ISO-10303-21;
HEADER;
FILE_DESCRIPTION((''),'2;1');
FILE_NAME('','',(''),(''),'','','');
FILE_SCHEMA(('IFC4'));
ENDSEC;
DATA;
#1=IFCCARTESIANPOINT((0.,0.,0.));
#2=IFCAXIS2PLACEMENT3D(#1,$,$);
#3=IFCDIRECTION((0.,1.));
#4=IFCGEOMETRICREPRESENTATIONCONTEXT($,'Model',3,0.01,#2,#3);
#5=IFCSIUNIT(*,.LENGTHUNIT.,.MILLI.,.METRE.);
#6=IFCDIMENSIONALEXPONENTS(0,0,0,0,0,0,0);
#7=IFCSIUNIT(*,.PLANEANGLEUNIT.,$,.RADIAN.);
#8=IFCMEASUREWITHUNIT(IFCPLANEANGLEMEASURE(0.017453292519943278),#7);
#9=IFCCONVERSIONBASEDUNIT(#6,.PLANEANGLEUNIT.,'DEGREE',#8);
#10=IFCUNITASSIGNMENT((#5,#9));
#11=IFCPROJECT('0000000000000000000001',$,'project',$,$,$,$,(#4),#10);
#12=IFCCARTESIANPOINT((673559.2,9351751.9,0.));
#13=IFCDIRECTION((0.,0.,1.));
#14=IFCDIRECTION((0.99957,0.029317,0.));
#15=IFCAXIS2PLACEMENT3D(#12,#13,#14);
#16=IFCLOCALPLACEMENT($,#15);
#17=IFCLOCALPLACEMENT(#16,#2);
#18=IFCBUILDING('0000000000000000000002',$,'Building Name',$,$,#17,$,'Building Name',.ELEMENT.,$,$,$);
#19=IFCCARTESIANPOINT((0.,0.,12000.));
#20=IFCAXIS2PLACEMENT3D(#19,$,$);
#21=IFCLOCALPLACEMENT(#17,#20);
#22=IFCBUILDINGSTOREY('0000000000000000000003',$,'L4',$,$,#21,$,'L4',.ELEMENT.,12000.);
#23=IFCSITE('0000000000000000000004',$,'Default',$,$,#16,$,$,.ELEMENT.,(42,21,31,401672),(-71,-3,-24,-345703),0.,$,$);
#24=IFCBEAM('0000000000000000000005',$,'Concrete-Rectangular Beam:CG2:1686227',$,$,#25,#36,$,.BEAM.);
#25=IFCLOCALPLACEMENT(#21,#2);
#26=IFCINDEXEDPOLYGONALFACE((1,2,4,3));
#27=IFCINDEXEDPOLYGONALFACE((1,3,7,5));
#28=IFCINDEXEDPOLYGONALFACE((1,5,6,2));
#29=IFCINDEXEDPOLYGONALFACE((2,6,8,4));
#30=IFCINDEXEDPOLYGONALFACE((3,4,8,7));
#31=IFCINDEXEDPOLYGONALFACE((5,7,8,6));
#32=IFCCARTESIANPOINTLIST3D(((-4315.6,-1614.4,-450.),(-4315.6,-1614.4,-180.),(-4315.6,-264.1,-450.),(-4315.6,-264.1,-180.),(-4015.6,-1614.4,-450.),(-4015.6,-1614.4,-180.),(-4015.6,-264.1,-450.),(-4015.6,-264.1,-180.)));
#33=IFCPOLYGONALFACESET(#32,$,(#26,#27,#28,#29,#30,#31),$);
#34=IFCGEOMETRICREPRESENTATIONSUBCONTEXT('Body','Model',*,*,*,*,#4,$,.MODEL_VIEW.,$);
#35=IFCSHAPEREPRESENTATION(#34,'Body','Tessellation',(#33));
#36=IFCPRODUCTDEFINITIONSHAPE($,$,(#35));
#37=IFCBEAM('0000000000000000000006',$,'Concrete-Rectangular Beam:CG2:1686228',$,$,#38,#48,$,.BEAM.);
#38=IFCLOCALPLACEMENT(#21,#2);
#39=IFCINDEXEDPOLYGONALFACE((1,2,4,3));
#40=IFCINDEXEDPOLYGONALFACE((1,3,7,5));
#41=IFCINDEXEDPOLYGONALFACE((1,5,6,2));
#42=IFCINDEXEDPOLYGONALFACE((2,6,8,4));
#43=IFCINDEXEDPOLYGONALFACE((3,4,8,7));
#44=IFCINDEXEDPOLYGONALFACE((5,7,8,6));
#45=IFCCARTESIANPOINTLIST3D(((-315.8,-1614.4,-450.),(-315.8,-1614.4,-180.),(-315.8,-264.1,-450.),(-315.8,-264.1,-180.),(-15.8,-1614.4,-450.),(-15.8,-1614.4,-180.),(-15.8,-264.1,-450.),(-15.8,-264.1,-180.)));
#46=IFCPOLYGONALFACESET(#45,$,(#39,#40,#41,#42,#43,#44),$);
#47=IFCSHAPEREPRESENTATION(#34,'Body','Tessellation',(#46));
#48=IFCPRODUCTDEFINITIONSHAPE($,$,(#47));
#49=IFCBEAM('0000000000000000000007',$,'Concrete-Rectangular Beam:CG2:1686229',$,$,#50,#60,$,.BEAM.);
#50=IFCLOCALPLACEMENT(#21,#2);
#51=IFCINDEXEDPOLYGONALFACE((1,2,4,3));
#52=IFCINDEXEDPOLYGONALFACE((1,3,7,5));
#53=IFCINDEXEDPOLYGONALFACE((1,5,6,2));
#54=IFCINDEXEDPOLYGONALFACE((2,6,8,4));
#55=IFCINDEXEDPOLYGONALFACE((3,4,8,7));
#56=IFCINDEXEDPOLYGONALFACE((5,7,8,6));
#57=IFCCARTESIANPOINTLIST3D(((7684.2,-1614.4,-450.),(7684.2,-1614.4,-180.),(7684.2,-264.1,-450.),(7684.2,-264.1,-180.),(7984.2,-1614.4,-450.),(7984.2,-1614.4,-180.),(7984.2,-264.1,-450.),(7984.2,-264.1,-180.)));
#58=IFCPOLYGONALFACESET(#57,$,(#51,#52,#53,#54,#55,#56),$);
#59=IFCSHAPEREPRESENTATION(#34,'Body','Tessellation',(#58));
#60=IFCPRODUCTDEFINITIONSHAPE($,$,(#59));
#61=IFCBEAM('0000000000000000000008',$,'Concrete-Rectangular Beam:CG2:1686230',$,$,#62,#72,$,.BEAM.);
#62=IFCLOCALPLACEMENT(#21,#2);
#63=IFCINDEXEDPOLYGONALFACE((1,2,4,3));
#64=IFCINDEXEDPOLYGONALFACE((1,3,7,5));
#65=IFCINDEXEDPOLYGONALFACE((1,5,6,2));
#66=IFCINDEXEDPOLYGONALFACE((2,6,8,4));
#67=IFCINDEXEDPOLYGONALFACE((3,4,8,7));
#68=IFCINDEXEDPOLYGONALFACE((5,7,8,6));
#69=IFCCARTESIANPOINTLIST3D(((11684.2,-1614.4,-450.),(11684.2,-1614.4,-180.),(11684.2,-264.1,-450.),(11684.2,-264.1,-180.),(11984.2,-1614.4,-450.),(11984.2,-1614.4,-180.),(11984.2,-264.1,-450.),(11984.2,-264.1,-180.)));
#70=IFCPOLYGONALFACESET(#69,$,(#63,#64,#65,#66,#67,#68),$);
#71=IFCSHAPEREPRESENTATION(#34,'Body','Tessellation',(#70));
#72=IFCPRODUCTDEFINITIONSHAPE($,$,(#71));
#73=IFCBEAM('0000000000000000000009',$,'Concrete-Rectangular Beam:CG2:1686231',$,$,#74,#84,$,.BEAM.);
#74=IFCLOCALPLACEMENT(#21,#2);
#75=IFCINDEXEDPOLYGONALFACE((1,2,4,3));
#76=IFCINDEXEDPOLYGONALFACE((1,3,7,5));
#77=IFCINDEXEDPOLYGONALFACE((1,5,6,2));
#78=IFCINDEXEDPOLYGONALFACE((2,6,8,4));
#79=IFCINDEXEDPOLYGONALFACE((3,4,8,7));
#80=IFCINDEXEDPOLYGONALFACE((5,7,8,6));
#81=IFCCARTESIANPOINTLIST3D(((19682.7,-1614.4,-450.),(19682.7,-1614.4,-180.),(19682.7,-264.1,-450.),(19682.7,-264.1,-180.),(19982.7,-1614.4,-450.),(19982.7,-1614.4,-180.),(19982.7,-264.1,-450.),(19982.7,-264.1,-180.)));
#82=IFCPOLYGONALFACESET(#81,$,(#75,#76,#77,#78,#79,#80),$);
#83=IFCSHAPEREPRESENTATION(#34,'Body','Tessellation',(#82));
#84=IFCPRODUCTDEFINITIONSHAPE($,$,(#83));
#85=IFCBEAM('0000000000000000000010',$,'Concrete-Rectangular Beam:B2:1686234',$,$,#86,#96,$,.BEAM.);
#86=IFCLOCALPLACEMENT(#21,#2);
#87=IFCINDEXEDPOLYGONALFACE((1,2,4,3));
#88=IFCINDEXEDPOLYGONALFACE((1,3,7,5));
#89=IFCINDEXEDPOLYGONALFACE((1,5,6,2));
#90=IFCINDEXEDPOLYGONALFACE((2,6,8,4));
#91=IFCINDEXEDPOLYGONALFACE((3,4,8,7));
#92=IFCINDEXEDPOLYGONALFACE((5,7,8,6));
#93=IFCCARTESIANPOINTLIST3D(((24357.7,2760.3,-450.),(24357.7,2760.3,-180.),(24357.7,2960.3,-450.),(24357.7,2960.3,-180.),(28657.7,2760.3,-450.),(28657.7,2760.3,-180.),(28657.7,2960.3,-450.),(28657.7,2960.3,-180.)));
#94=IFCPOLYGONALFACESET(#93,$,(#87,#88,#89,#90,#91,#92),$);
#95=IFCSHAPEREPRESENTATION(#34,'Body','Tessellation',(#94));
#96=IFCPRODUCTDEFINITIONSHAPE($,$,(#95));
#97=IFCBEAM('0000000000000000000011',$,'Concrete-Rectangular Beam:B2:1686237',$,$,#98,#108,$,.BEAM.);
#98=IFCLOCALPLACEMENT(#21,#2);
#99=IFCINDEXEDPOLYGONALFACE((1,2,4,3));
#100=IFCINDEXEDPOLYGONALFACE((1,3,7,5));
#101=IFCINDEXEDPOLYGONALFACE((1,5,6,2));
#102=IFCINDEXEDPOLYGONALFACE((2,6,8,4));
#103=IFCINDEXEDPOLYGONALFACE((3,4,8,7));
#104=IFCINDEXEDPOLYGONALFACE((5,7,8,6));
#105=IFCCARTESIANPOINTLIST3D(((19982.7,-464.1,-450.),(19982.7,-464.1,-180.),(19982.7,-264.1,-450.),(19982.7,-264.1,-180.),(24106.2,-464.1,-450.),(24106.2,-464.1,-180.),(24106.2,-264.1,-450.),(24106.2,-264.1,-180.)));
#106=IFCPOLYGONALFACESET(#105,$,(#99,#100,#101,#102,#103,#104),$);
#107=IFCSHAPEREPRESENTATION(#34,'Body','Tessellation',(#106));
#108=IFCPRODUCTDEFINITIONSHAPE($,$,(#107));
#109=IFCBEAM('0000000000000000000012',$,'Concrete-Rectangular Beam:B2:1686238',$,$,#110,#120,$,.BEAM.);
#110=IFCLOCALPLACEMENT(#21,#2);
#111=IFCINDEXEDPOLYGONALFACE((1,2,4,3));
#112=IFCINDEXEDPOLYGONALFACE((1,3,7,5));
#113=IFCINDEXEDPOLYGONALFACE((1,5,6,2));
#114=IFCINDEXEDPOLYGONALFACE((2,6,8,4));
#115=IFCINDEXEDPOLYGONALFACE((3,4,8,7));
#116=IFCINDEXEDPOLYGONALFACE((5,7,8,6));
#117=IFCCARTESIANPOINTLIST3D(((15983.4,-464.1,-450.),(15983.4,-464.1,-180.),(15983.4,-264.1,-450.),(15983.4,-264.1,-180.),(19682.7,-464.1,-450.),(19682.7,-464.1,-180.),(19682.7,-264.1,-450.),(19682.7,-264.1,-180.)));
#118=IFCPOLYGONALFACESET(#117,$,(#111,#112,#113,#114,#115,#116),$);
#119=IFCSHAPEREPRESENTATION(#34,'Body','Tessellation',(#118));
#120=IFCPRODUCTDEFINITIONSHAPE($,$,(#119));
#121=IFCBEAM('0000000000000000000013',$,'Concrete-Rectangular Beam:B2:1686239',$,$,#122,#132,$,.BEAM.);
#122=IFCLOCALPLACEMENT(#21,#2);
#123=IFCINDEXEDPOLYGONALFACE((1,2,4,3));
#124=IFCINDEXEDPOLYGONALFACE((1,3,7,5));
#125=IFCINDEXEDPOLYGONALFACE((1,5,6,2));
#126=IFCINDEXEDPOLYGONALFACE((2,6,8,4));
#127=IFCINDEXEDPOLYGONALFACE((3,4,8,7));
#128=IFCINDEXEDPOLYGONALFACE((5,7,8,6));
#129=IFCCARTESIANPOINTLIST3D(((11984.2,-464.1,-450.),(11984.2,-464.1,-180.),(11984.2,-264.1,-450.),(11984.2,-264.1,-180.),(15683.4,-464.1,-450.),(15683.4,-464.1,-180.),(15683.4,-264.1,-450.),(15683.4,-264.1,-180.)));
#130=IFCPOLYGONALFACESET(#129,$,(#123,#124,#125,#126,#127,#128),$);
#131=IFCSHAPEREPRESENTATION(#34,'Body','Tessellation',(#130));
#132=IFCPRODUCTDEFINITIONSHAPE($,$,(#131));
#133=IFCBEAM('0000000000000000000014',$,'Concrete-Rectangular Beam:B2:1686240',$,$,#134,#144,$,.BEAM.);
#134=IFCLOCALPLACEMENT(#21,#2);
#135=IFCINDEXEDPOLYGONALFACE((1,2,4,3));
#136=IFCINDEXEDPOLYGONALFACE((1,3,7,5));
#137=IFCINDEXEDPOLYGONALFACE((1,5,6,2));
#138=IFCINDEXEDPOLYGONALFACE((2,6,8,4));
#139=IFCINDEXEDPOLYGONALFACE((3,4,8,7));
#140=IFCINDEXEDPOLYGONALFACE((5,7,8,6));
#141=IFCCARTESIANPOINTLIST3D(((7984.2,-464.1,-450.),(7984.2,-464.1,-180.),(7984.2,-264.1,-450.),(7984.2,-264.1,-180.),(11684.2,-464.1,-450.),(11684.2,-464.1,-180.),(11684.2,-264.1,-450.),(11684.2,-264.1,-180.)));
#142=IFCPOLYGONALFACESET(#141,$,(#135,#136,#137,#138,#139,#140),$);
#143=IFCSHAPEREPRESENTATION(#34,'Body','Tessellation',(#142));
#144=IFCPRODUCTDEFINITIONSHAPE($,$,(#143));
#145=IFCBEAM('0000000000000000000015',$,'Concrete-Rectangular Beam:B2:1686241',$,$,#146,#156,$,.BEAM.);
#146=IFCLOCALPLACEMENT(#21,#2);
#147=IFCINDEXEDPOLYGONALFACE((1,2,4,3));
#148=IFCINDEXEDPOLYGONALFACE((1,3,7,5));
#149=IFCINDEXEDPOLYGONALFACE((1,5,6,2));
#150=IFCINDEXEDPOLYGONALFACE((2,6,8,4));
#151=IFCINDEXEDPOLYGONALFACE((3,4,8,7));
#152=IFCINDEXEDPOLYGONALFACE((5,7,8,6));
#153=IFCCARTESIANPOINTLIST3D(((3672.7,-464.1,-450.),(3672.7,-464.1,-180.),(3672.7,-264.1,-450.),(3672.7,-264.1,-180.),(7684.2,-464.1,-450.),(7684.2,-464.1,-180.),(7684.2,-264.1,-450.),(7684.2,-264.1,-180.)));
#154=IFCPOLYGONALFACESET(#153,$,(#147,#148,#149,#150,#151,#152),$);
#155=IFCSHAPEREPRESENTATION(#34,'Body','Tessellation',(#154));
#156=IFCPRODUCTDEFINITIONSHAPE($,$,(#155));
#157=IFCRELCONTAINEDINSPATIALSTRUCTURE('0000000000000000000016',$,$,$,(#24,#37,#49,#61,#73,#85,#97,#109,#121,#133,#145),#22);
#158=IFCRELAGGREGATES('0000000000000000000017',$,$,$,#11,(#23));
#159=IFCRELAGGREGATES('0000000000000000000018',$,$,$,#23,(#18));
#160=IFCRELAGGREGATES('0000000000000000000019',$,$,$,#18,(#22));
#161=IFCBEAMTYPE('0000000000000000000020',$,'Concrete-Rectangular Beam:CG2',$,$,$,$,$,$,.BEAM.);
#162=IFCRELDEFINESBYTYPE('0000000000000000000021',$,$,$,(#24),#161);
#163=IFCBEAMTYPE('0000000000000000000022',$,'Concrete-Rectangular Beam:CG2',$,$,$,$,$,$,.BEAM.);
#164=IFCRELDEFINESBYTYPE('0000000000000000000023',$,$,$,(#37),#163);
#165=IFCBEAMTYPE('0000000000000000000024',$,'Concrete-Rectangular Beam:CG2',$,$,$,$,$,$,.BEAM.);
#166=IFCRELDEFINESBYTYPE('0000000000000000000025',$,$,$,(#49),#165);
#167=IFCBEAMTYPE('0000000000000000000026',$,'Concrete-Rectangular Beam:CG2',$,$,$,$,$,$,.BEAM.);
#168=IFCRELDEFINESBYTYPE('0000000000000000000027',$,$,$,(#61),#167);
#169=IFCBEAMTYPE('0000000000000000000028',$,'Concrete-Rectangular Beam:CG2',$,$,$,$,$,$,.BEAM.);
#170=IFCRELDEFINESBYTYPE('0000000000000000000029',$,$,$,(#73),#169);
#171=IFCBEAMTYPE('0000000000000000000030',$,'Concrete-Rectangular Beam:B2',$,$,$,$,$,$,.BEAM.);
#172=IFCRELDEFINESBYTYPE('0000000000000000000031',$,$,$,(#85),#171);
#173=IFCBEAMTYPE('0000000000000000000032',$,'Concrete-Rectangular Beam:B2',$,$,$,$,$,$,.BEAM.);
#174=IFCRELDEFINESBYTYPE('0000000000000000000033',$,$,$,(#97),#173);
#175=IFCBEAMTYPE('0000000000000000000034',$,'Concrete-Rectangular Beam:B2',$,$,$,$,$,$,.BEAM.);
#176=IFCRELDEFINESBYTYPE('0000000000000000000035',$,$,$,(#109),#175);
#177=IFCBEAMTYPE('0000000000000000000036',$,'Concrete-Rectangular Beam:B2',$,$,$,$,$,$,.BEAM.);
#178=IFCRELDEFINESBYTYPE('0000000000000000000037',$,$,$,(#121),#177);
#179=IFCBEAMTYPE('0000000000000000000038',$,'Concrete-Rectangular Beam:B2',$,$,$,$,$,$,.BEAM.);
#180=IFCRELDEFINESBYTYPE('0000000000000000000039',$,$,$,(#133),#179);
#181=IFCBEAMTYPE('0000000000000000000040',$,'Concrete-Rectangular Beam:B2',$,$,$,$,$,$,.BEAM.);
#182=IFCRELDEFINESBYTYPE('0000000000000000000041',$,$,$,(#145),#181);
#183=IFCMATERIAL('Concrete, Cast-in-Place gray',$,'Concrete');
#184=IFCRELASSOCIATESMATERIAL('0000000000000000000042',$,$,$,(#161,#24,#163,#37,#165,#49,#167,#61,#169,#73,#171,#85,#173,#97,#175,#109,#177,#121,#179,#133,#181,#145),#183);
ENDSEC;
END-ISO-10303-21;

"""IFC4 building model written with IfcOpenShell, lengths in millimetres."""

from ifc_helpers import new_model, entity, si_unit, converted_unit, direction, frame, origin, place, context, subcontext, project, spatial, indexed_curve, outline, extrude, source, transform, mapped, material, type_object, type_shapes, element, save


model = new_model("IFC4")

# Units and contexts
model_context = context("Model", 3, precision=0.01, world=origin(), true_north=direction((0.0, 1.0)))
body_context = subcontext(model_context, "Body", "Model", "MODEL_VIEW")
ifc_project = project(units=[si_unit("LENGTHUNIT", "METRE", prefix="MILLI"), converted_unit("PLANEANGLEUNIT", "DEGREE", entity("IfcPlaneAngleMeasure", 0.017453292519943278), si_unit("PLANEANGLEUNIT", "RADIAN"), dimensions=[0, 0, 0, 0, 0, 0, 0])], contexts=[model_context])

# Site, building, storey
site_placement = place(None, frame((673559.2, 9351751.9, 0.0), z_axis=(0.0, 0.0, 1.0), x_axis=(0.99957, 0.029317, 0.0)))
site = spatial("IfcSite", under=ifc_project, at=site_placement, Name="Default", CompositionType="ELEMENT", RefLatitude=(42, 21, 31, 401672), RefLongitude=(-71, -3, -24, -345703), RefElevation=0.0)
building_placement = place(site_placement, origin())
building = spatial("IfcBuilding", under=site, at=building_placement, Name="Building Name", LongName="Building Name", CompositionType="ELEMENT")
storey_placement = place(building_placement, frame((0.0, 0.0, 12000.0)))
storey = spatial("IfcBuildingStorey", under=building, at=storey_placement, Name="L4", LongName="L4", CompositionType="ELEMENT", Elevation=12000.0)

# Beams
ifc_material = material(Name="Concrete, Cast-in-Place gray", Category="Concrete")
beam_type_1 = type_object("IfcBeamType", Name="Concrete-Rectangular Beam:CG2", PredefinedType="BEAM", material=ifc_material)
shared_shape_1 = source(origin(), body_context, "Body", "SweptSolid", [
    extrude(outline(indexed_curve([(-150.0, -135.0), (150.0, -135.0), (150.0, 135.0), (-150.0, 135.0), (-150.0, -135.0)], self_intersect=False)), frame((-4165.6, -1614.4, 11685.0), z_axis=(0.0, 1.0, 0.0), x_axis=(-1.0, 0.0, 0.0)), (0.0, 0.0, 1.0), 1350.4),
])
type_shapes(beam_type_1, [shared_shape_1])
beam_1_placement = place(storey_placement, frame((0.0, 0.0, -12000.0)))
element("IfcBeam", 1, at=beam_1_placement, inside=storey, type_object=beam_type_1, material=ifc_material, Name="Concrete-Rectangular Beam:CG2:1686227", PredefinedType="BEAM", context=body_context, shape_type="MappedRepresentation", body=[
    mapped(shared_shape_1, transform((0.0, 0.0, 0.0), scale=1.0)),
])
beam_type_2 = type_object("IfcBeamType", Name="Concrete-Rectangular Beam:CG2", PredefinedType="BEAM", material=ifc_material)
shared_shape_2 = source(origin(), body_context, "Body", "SweptSolid", [
    extrude(outline(indexed_curve([(-150.0, -135.0), (150.0, -135.0), (150.0, 135.0), (-150.0, 135.0), (-150.0, -135.0)], self_intersect=False)), frame((-165.8, -1614.4, 11685.0), z_axis=(0.0, 1.0, 0.0), x_axis=(-1.0, 0.0, 0.0)), (0.0, 0.0, 1.0), 1350.4),
])
type_shapes(beam_type_2, [shared_shape_2])
beam_2_placement = place(storey_placement, frame((0.0, 0.0, -12000.0)))
element("IfcBeam", 2, at=beam_2_placement, inside=storey, type_object=beam_type_2, material=ifc_material, Name="Concrete-Rectangular Beam:CG2:1686228", PredefinedType="BEAM", context=body_context, shape_type="MappedRepresentation", body=[
    mapped(shared_shape_2, transform((0.0, 0.0, 0.0), scale=1.0)),
])
beam_type_3 = type_object("IfcBeamType", Name="Concrete-Rectangular Beam:CG2", PredefinedType="BEAM", material=ifc_material)
shared_shape_3 = source(origin(), body_context, "Body", "SweptSolid", [
    extrude(outline(indexed_curve([(-150.0, -135.0), (150.0, -135.0), (150.0, 135.0), (-150.0, 135.0), (-150.0, -135.0)], self_intersect=False)), frame((7834.2, -1614.4, 11685.0), z_axis=(0.0, 1.0, 0.0), x_axis=(-1.0, 0.0, 0.0)), (0.0, 0.0, 1.0), 1350.4),
])
type_shapes(beam_type_3, [shared_shape_3])
beam_3_placement = place(storey_placement, frame((0.0, 0.0, -12000.0)))
element("IfcBeam", 3, at=beam_3_placement, inside=storey, type_object=beam_type_3, material=ifc_material, Name="Concrete-Rectangular Beam:CG2:1686229", PredefinedType="BEAM", context=body_context, shape_type="MappedRepresentation", body=[
    mapped(shared_shape_3, transform((0.0, 0.0, 0.0), scale=1.0)),
])
beam_type_4 = type_object("IfcBeamType", Name="Concrete-Rectangular Beam:CG2", PredefinedType="BEAM", material=ifc_material)
shared_shape_4 = source(origin(), body_context, "Body", "SweptSolid", [
    extrude(outline(indexed_curve([(-150.0, -135.0), (150.0, -135.0), (150.0, 135.0), (-150.0, 135.0), (-150.0, -135.0)], self_intersect=False)), frame((11834.2, -1614.4, 11685.0), z_axis=(0.0, 1.0, 0.0), x_axis=(-1.0, 0.0, 0.0)), (0.0, 0.0, 1.0), 1350.4),
])
type_shapes(beam_type_4, [shared_shape_4])
beam_4_placement = place(storey_placement, frame((0.0, 0.0, -12000.0)))
element("IfcBeam", 4, at=beam_4_placement, inside=storey, type_object=beam_type_4, material=ifc_material, Name="Concrete-Rectangular Beam:CG2:1686230", PredefinedType="BEAM", context=body_context, shape_type="MappedRepresentation", body=[
    mapped(shared_shape_4, transform((0.0, 0.0, 0.0), scale=1.0)),
])
beam_type_5 = type_object("IfcBeamType", Name="Concrete-Rectangular Beam:CG2", PredefinedType="BEAM", material=ifc_material)
shared_shape_5 = source(origin(), body_context, "Body", "SweptSolid", [
    extrude(outline(indexed_curve([(-150.0, -135.0), (150.0, -135.0), (150.0, 135.0), (-150.0, 135.0), (-150.0, -135.0)], self_intersect=False)), frame((19832.7, -1614.4, 11685.0), z_axis=(0.0, 1.0, 0.0), x_axis=(-1.0, 0.0, 0.0)), (0.0, 0.0, 1.0), 1350.4),
])
type_shapes(beam_type_5, [shared_shape_5])
beam_5_placement = place(storey_placement, frame((0.0, 0.0, -12000.0)))
element("IfcBeam", 5, at=beam_5_placement, inside=storey, type_object=beam_type_5, material=ifc_material, Name="Concrete-Rectangular Beam:CG2:1686231", PredefinedType="BEAM", context=body_context, shape_type="MappedRepresentation", body=[
    mapped(shared_shape_5, transform((0.0, 0.0, 0.0), scale=1.0)),
])
beam_type_6 = type_object("IfcBeamType", Name="Concrete-Rectangular Beam:B2", PredefinedType="BEAM", material=ifc_material)
shared_shape_6 = source(origin(), body_context, "Body", "SweptSolid", [
    extrude(outline(indexed_curve([(-135.0, -100.0), (135.0, -100.0), (135.0, 100.0), (-135.0, 100.0), (-135.0, -100.0)], self_intersect=False)), frame((24357.7, 2860.3, 11685.0), z_axis=(1.0, 0.0, 0.0), x_axis=(0.0, 0.0, -1.0)), (0.0, 0.0, 1.0), 4300.0),
])
type_shapes(beam_type_6, [shared_shape_6])
beam_6_placement = place(storey_placement, frame((0.0, 0.0, -12000.0)))
element("IfcBeam", 6, at=beam_6_placement, inside=storey, type_object=beam_type_6, material=ifc_material, Name="Concrete-Rectangular Beam:B2:1686234", PredefinedType="BEAM", context=body_context, shape_type="MappedRepresentation", body=[
    mapped(shared_shape_6, transform((0.0, 0.0, 0.0), scale=1.0)),
])
beam_type_7 = type_object("IfcBeamType", Name="Concrete-Rectangular Beam:B2", PredefinedType="BEAM", material=ifc_material)
shared_shape_7 = source(origin(), body_context, "Body", "SweptSolid", [
    extrude(outline(indexed_curve([(-135.0, -100.0), (135.0, -100.0), (135.0, 100.0), (-135.0, 100.0), (-135.0, -100.0)], self_intersect=False)), frame((24106.2, -364.1, 11685.0), z_axis=(-1.0, 0.0, 0.0), x_axis=(0.0, 0.0, -1.0)), (0.0, 0.0, 1.0), 4123.5),
])
type_shapes(beam_type_7, [shared_shape_7])
beam_7_placement = place(storey_placement, frame((0.0, 0.0, -12000.0)))
element("IfcBeam", 7, at=beam_7_placement, inside=storey, type_object=beam_type_7, material=ifc_material, Name="Concrete-Rectangular Beam:B2:1686237", PredefinedType="BEAM", context=body_context, shape_type="MappedRepresentation", body=[
    mapped(shared_shape_7, transform((0.0, 0.0, 0.0), scale=1.0)),
])
beam_type_8 = type_object("IfcBeamType", Name="Concrete-Rectangular Beam:B2", PredefinedType="BEAM", material=ifc_material)
shared_shape_8 = source(origin(), body_context, "Body", "SweptSolid", [
    extrude(outline(indexed_curve([(-135.0, -100.0), (135.0, -100.0), (135.0, 100.0), (-135.0, 100.0), (-135.0, -100.0)], self_intersect=False)), frame((19682.7, -364.1, 11685.0), z_axis=(-1.0, 0.0, 0.0), x_axis=(0.0, 0.0, -1.0)), (0.0, 0.0, 1.0), 3699.3),
])
type_shapes(beam_type_8, [shared_shape_8])
beam_8_placement = place(storey_placement, frame((0.0, 0.0, -12000.0)))
element("IfcBeam", 8, at=beam_8_placement, inside=storey, type_object=beam_type_8, material=ifc_material, Name="Concrete-Rectangular Beam:B2:1686238", PredefinedType="BEAM", context=body_context, shape_type="MappedRepresentation", body=[
    mapped(shared_shape_8, transform((0.0, 0.0, 0.0), scale=1.0)),
])
beam_type_9 = type_object("IfcBeamType", Name="Concrete-Rectangular Beam:B2", PredefinedType="BEAM", material=ifc_material)
shared_shape_9 = source(origin(), body_context, "Body", "SweptSolid", [
    extrude(outline(indexed_curve([(-135.0, -100.0), (135.0, -100.0), (135.0, 100.0), (-135.0, 100.0), (-135.0, -100.0)], self_intersect=False)), frame((11984.2, -364.1, 11685.0), z_axis=(1.0, 0.0, 0.0), x_axis=(0.0, 0.0, -1.0)), (0.0, 0.0, 1.0), 3699.3),
])
type_shapes(beam_type_9, [shared_shape_9])
beam_9_placement = place(storey_placement, frame((0.0, 0.0, -12000.0)))
element("IfcBeam", 9, at=beam_9_placement, inside=storey, type_object=beam_type_9, material=ifc_material, Name="Concrete-Rectangular Beam:B2:1686239", PredefinedType="BEAM", context=body_context, shape_type="MappedRepresentation", body=[
    mapped(shared_shape_9, transform((0.0, 0.0, 0.0), scale=1.0)),
])
beam_type_10 = type_object("IfcBeamType", Name="Concrete-Rectangular Beam:B2", PredefinedType="BEAM", material=ifc_material)
shared_shape_10 = source(origin(), body_context, "Body", "SweptSolid", [
    extrude(outline(indexed_curve([(-135.0, -100.0), (135.0, -100.0), (135.0, 100.0), (-135.0, 100.0), (-135.0, -100.0)], self_intersect=False)), frame((11684.2, -364.1, 11685.0), z_axis=(-1.0, 0.0, 0.0), x_axis=(0.0, 0.0, -1.0)), (0.0, 0.0, 1.0), 3700.0),
])
type_shapes(beam_type_10, [shared_shape_10])
beam_10_placement = place(storey_placement, frame((0.0, 0.0, -12000.0)))
element("IfcBeam", 10, at=beam_10_placement, inside=storey, type_object=beam_type_10, material=ifc_material, Name="Concrete-Rectangular Beam:B2:1686240", PredefinedType="BEAM", context=body_context, shape_type="MappedRepresentation", body=[
    mapped(shared_shape_10, transform((0.0, 0.0, 0.0), scale=1.0)),
])
beam_type_11 = type_object("IfcBeamType", Name="Concrete-Rectangular Beam:B2", PredefinedType="BEAM", material=ifc_material)
shared_shape_11 = source(origin(), body_context, "Body", "SweptSolid", [
    extrude(outline(indexed_curve([(-135.0, -100.0), (135.0, -100.0), (135.0, 100.0), (-135.0, 100.0), (-135.0, -100.0)], self_intersect=False)), frame((7684.2, -364.1, 11685.0), z_axis=(-1.0, 0.0, 0.0), x_axis=(0.0, 0.0, -1.0)), (0.0, 0.0, 1.0), 4011.4),
])
type_shapes(beam_type_11, [shared_shape_11])
beam_11_placement = place(storey_placement, frame((0.0, 0.0, -12000.0)))
element("IfcBeam", 11, at=beam_11_placement, inside=storey, type_object=beam_type_11, material=ifc_material, Name="Concrete-Rectangular Beam:B2:1686241", PredefinedType="BEAM", context=body_context, shape_type="MappedRepresentation", body=[
    mapped(shared_shape_11, transform((0.0, 0.0, 0.0), scale=1.0)),
])

save(model, "model.ifc")
